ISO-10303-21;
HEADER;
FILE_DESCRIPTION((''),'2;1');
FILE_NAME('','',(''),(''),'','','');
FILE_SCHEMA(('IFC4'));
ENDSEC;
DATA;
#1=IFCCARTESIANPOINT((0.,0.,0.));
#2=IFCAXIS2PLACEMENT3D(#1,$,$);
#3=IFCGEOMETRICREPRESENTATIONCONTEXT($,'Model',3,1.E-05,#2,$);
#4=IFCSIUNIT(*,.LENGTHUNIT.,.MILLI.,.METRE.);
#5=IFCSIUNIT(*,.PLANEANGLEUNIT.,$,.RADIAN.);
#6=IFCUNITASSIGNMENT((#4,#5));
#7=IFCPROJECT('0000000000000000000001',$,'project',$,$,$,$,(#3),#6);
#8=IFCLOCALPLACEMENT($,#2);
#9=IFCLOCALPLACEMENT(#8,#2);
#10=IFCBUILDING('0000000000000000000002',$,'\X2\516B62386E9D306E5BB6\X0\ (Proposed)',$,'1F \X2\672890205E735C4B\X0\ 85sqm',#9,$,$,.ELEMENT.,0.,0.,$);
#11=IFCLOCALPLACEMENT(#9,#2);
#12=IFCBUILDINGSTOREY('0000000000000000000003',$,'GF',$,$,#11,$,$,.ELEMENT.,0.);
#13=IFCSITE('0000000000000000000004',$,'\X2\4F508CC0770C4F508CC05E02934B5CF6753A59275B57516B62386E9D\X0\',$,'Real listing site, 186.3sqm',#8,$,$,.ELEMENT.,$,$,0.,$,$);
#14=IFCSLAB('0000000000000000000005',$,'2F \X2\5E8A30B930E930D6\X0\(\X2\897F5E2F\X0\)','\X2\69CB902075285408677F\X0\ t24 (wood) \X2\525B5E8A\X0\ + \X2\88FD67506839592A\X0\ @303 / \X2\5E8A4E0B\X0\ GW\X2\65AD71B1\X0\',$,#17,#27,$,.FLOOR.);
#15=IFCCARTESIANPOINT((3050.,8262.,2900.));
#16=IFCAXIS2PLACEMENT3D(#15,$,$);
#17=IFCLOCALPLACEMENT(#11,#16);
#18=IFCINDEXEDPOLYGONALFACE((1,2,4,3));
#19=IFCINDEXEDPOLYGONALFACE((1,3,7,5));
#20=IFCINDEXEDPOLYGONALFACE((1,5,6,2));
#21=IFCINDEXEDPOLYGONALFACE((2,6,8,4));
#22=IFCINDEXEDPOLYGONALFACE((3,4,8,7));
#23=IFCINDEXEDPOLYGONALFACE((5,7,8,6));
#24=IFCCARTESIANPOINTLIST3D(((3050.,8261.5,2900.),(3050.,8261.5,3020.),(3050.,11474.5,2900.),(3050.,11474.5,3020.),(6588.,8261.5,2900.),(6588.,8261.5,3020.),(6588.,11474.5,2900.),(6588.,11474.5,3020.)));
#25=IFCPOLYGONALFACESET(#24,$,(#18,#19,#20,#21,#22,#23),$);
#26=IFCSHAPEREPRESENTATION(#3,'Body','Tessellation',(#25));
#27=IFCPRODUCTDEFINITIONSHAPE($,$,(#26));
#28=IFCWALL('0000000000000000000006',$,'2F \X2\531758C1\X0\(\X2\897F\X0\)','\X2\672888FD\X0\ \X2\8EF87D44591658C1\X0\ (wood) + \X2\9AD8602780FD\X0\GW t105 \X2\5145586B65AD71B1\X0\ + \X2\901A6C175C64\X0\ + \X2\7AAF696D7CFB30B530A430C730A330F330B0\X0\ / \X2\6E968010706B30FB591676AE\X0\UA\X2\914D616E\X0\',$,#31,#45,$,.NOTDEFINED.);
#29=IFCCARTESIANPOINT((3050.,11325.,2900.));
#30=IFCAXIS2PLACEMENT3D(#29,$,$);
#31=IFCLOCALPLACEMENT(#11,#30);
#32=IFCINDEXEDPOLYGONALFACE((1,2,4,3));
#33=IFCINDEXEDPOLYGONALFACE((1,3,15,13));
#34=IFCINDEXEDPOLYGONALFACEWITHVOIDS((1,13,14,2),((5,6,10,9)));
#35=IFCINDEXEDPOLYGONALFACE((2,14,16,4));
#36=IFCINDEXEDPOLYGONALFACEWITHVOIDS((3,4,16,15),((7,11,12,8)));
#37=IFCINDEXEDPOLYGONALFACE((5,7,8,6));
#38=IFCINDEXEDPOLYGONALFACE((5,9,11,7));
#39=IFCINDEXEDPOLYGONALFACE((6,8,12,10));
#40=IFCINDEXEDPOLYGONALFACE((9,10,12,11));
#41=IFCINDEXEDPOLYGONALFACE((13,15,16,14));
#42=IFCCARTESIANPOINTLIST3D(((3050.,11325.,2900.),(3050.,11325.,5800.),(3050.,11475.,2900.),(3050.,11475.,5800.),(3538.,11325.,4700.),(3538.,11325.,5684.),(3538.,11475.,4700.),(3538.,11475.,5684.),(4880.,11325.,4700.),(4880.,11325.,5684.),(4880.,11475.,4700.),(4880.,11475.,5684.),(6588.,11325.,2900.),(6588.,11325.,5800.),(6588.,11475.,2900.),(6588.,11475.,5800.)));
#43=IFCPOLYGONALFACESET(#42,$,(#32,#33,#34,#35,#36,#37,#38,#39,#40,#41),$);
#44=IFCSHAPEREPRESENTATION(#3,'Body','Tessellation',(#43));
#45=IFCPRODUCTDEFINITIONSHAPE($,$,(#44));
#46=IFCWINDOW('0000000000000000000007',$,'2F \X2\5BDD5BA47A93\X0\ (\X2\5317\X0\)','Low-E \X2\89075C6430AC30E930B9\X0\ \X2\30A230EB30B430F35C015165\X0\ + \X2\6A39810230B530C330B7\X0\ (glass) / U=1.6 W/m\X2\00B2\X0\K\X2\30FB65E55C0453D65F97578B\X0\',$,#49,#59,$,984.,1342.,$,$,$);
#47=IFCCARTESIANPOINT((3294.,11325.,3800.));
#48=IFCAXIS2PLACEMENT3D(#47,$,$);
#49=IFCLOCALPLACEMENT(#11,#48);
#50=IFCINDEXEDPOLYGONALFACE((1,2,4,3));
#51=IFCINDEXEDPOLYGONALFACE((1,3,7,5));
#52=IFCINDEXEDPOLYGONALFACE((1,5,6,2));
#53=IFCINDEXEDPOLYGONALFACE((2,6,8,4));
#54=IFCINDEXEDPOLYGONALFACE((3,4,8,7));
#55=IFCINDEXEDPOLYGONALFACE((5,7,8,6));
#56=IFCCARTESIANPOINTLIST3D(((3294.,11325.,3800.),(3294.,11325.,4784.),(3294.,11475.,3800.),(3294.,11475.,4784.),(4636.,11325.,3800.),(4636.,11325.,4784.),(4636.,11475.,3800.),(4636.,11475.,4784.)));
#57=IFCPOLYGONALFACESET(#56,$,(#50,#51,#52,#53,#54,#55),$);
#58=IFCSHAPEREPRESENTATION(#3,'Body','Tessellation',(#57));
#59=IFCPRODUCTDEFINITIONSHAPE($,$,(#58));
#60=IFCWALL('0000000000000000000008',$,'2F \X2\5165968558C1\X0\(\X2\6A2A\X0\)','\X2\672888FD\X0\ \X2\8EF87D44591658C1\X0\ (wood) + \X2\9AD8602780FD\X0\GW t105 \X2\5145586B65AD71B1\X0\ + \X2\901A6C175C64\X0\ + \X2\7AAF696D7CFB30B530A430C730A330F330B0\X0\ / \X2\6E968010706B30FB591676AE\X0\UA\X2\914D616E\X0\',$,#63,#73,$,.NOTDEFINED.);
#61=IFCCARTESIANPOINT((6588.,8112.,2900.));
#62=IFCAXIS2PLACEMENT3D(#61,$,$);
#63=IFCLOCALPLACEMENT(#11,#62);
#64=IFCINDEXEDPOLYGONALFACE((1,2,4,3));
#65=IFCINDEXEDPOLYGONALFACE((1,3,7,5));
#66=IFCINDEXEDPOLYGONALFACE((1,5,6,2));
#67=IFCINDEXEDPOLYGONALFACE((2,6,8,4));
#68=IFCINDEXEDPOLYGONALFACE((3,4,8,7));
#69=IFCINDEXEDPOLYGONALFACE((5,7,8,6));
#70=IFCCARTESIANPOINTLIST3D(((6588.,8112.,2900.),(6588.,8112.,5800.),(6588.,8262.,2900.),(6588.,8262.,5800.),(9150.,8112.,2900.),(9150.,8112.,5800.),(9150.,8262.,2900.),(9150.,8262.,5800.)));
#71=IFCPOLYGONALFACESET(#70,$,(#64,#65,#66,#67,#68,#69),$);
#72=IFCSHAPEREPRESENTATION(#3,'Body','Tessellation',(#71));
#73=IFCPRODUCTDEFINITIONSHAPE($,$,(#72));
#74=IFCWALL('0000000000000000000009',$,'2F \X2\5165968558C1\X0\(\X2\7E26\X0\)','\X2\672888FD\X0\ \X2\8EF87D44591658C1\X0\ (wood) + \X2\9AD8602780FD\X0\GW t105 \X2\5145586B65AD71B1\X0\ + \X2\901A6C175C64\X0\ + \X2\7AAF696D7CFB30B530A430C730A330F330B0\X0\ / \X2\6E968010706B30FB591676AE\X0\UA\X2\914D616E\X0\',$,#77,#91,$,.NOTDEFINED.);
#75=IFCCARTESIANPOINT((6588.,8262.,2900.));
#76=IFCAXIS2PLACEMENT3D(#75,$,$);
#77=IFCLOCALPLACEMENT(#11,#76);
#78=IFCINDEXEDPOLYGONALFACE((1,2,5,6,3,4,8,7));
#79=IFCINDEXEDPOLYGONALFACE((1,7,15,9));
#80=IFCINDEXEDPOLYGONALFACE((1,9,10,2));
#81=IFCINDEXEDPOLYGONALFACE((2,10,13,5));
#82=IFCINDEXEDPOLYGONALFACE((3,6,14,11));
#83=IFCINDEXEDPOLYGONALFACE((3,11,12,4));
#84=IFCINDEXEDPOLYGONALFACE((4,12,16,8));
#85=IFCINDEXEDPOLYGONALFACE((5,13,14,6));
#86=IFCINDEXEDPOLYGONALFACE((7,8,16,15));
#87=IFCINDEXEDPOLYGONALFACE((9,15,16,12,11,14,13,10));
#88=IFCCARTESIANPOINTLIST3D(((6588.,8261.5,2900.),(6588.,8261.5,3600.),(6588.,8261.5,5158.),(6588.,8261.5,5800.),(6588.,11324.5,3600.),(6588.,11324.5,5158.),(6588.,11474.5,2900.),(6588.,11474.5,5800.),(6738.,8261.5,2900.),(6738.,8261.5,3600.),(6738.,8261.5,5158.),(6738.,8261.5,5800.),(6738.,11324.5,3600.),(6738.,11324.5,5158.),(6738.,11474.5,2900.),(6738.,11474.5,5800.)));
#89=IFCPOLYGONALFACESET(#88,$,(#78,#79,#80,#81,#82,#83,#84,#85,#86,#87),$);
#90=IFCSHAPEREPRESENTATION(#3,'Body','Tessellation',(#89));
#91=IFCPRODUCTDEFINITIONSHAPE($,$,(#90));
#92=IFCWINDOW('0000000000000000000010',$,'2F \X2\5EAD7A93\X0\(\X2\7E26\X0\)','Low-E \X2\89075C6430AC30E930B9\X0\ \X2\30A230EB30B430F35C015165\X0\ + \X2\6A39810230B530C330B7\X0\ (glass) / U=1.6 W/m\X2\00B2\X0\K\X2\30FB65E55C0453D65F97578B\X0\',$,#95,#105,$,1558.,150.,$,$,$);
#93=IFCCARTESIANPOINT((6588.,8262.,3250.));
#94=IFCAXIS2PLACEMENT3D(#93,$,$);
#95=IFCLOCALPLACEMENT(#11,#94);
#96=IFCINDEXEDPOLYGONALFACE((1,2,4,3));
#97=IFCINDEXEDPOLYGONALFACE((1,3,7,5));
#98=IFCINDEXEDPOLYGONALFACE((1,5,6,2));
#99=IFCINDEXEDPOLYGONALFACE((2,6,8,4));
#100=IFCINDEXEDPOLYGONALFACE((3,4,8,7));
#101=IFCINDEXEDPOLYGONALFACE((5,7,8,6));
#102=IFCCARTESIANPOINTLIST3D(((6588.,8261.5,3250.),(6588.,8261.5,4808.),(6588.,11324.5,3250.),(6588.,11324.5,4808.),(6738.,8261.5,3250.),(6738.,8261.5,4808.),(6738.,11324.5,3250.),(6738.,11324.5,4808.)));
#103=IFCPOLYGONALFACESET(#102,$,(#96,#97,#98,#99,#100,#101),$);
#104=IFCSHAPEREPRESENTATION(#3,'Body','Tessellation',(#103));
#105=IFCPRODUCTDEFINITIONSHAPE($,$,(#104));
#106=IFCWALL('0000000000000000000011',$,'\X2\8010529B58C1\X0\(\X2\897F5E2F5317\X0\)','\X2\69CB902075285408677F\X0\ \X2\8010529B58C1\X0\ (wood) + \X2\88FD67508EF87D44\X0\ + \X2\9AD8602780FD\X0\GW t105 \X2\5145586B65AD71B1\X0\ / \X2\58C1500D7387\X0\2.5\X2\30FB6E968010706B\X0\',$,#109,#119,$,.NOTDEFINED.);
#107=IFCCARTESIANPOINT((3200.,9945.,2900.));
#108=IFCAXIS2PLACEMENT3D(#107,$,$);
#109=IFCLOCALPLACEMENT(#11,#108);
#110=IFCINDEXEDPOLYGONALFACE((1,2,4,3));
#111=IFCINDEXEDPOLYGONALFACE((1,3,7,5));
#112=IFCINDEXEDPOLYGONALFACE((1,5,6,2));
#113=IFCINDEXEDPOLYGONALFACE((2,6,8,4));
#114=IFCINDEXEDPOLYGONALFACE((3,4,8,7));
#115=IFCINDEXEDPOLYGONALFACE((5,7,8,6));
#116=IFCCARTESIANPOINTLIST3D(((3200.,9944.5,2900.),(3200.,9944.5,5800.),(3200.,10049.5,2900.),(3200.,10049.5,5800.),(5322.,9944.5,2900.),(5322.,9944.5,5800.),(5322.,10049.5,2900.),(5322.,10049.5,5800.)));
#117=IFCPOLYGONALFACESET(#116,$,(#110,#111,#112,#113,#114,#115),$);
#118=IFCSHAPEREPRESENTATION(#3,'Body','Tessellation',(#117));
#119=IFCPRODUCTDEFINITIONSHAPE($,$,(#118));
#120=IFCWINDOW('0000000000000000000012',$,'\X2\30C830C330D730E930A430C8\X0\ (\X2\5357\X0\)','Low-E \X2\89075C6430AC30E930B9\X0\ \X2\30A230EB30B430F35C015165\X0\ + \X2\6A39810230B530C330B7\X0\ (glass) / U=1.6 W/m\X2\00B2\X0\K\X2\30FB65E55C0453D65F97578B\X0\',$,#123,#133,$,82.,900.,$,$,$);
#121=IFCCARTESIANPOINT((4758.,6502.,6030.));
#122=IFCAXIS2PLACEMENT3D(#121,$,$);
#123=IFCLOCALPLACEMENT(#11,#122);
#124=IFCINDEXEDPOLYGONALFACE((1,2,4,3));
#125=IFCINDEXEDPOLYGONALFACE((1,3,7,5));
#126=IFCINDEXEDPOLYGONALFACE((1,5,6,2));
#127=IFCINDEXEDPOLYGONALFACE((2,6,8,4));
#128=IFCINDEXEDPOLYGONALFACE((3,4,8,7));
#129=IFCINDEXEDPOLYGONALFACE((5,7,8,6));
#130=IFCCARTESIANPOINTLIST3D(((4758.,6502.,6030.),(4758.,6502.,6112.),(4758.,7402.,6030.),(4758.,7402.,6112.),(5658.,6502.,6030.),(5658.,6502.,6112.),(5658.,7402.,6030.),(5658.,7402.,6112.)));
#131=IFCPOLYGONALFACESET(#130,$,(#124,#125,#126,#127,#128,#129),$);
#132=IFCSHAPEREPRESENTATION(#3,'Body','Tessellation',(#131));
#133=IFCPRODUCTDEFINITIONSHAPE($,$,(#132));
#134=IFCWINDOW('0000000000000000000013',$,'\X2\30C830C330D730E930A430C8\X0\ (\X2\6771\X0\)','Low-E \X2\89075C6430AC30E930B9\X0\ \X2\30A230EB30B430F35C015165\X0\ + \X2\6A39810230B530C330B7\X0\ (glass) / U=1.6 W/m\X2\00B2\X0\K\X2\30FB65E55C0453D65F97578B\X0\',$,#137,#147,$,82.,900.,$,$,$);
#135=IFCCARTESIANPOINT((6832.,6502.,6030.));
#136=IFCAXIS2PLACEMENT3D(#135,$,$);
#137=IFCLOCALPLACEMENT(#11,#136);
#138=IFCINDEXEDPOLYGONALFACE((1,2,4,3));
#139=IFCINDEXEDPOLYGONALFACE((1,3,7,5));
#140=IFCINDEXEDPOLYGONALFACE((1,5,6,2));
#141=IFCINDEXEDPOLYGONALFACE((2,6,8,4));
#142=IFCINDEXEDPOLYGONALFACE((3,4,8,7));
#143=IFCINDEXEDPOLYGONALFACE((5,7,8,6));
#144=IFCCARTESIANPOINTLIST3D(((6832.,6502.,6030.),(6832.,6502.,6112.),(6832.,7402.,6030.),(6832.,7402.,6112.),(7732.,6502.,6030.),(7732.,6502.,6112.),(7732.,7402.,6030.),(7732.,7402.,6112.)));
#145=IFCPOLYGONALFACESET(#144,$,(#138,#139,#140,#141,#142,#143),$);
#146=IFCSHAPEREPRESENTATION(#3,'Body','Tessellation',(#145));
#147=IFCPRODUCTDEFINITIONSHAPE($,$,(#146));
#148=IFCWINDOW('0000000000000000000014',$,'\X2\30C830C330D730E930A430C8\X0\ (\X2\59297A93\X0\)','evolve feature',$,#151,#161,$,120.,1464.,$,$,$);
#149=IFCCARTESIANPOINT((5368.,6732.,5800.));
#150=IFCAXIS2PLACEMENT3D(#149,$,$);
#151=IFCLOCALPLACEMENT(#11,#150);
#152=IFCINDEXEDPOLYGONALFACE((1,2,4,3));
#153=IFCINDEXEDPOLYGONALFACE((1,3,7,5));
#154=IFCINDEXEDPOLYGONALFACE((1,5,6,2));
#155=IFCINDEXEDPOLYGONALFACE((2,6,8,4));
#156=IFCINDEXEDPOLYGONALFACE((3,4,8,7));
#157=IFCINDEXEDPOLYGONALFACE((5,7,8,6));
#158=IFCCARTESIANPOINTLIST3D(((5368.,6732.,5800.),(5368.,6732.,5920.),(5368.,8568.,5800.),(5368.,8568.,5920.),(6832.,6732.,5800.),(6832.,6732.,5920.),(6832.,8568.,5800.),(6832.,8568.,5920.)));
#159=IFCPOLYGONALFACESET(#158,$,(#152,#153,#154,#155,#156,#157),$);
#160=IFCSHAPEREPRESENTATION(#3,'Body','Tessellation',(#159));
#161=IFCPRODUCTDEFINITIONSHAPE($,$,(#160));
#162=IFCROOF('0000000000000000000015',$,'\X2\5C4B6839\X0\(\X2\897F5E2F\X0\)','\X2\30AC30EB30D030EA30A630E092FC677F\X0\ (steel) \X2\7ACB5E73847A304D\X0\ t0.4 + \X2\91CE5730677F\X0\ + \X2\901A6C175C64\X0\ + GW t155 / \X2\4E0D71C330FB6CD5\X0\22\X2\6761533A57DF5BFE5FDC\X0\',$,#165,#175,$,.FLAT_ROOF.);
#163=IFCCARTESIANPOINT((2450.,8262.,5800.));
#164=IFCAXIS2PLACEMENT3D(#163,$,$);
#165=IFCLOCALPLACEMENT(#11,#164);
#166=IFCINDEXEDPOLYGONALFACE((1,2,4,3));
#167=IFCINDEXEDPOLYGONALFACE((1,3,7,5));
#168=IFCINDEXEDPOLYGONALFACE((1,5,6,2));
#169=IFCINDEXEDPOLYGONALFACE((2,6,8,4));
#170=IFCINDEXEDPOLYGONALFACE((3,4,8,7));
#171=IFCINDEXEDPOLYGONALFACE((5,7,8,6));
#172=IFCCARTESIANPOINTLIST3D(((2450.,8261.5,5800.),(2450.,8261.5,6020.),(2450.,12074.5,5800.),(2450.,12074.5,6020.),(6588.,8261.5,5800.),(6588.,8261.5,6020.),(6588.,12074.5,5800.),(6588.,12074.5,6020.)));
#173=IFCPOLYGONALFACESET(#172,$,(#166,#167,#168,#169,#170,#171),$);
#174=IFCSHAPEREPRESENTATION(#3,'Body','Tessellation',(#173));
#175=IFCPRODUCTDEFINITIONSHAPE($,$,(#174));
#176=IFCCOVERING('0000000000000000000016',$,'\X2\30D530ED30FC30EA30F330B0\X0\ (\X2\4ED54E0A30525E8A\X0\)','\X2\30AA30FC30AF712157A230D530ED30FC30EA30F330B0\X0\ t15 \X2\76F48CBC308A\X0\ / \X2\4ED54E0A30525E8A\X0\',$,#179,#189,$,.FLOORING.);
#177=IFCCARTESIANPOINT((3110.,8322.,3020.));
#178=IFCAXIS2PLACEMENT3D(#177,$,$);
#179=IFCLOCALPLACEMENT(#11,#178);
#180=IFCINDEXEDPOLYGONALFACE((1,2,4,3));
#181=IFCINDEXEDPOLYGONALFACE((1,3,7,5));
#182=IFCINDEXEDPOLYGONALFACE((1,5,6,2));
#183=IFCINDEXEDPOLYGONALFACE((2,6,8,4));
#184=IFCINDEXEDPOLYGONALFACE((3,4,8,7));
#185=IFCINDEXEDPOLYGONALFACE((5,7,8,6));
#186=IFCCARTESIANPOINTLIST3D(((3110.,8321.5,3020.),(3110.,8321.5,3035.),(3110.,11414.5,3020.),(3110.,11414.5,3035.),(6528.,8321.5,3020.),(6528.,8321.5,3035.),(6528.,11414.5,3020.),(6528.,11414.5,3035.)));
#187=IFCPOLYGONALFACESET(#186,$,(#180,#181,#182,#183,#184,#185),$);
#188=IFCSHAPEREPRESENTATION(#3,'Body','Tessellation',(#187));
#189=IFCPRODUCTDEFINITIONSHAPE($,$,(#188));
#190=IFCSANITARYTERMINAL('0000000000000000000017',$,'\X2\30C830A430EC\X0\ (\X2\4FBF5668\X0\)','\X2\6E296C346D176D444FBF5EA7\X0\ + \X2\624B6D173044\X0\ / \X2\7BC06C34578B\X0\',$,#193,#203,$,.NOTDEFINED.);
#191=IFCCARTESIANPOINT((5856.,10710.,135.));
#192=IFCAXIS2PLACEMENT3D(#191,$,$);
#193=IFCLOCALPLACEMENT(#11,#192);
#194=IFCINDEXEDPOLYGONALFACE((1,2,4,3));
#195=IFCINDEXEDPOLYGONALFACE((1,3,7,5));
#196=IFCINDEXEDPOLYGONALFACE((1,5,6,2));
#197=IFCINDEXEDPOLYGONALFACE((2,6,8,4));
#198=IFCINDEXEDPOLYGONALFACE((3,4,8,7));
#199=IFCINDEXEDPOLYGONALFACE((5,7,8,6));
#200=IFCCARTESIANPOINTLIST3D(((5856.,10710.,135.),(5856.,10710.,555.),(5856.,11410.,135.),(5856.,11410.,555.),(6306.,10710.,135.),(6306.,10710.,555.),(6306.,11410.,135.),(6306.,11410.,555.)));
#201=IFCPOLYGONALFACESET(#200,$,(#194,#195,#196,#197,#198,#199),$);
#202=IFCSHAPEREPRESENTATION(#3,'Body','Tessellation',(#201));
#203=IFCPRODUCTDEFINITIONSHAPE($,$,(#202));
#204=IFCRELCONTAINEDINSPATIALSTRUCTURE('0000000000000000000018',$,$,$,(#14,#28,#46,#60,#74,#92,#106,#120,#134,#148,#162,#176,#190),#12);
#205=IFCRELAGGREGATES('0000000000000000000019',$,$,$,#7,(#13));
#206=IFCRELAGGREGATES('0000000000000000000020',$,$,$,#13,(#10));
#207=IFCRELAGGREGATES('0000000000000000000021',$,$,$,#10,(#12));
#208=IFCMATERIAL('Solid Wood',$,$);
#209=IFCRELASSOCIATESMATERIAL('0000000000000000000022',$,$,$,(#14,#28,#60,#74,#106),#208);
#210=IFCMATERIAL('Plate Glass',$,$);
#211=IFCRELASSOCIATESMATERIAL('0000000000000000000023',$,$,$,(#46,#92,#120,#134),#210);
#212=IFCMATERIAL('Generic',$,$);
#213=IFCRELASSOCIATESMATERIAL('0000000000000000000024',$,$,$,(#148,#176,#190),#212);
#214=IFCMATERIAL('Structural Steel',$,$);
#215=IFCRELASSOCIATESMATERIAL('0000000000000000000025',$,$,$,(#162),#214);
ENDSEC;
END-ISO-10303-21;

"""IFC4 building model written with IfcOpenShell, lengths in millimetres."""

from ifc_helpers import new_model, si_unit, frame, frame_2d, origin, place, context, project, spatial, rectangle, extrude, material, element, fill, save


model = new_model("IFC4")

# Units and contexts
model_context = context("Model", 3, precision=1e-05, world=origin())
ifc_project = project(units=[si_unit("LENGTHUNIT", "METRE", prefix="MILLI"), si_unit("PLANEANGLEUNIT", "RADIAN")], contexts=[model_context])

# Site, building, storey
site_placement = place(None, origin())
site = spatial("IfcSite", under=ifc_project, at=site_placement, Name="佐賀県佐賀市鍋島町大字八戸溝", ObjectType="Real listing site, 186.3sqm", CompositionType="ELEMENT", RefElevation=0.0)
building_placement = place(site_placement, origin())
building = spatial("IfcBuilding", under=site, at=building_placement, Name="八戸溝の家 (Proposed)", ObjectType="1F 木造平屋 85sqm", CompositionType="ELEMENT", ElevationOfRefHeight=0.0, ElevationOfTerrain=0.0)
storey_placement = place(building_placement, origin())
storey = spatial("IfcBuildingStorey", under=building, at=storey_placement, Name="GF", CompositionType="ELEMENT", Elevation=0.0)

# Slab
ifc_material_1 = material(Name="Solid Wood")
slab_placement = place(storey_placement, frame((3050.0, 8262.0, 2900.0)))
element("IfcSlab", 1, at=slab_placement, inside=storey, material=ifc_material_1, Name="2F 床スラブ(西帯)", Description="構造用合板 t24 (wood) 剛床 + 製材根太 @303 / 床下 GW断熱", PredefinedType="FLOOR", context=model_context, shape_type="SweptSolid", body=[
    extrude(rectangle(XDim=3538.0, YDim=3213.0, at=frame_2d((1769.0, 1606.0))), frame((3050.0, 8262.0, 2900.0)), (0.0, 0.0, 1.0), 120.0),
])

# Wall, opening, window
wall_1_placement = place(storey_placement, frame((3050.0, 11325.0, 2900.0)))
wall_1 = element("IfcWall", 2, at=wall_1_placement, inside=storey, material=ifc_material_1, Name="2F 北壁(西)", Description="木製 軸組外壁 (wood) + 高性能GW t105 充填断熱 + 通気層 + 窯業系サイディング / 準耐火・外皮UA配慮", PredefinedType="NOTDEFINED", context=model_context, shape_type="SweptSolid", body=[
    extrude(rectangle(XDim=3538.0, YDim=150.0, at=frame_2d((1769.0, 75.0))), frame((3050.0, 11325.0, 2900.0)), (0.0, 0.0, 1.0), 2900.0),
])
opening_1_placement = place(storey_placement, frame((3294.0, 11325.0, 3800.0)))
opening_1 = element("IfcOpeningElement", 3, at=opening_1_placement, cuts=wall_1, PredefinedType="NOTDEFINED", context=model_context, shape_type="SweptSolid", body=[
    extrude(rectangle(XDim=1342.0, YDim=150.0, at=frame_2d((671.0, 75.0))), frame((3294.0, 11325.0, 3800.0)), (0.0, 0.0, 1.0), 984.0),
])
ifc_material_2 = material(Name="Plate Glass")
window_1_placement = place(storey_placement, frame((3294.0, 11325.0, 3800.0)))
window_1 = element("IfcWindow", 4, at=window_1_placement, inside=storey, material=ifc_material_2, Name="2F 寝室窓 (北)", Description="Low-E 複層ガラス アルゴン封入 + 樹脂サッシ (glass) / U=1.6 W/m²K・日射取得型", OverallHeight=984.0, OverallWidth=1342.0, context=model_context, shape_type="SweptSolid", body=[
    extrude(rectangle(XDim=1342.0, YDim=150.0, at=frame_2d((671.0, 75.0))), frame((3294.0, 11325.0, 3800.0)), (0.0, 0.0, 1.0), 984.0),
])
fill(opening_1, window_1)

# Wall
wall_2_placement = place(storey_placement, frame((6588.0, 8112.0, 2900.0)))
element("IfcWall", 5, at=wall_2_placement, inside=storey, material=ifc_material_1, Name="2F 入隅壁(横)", Description="木製 軸組外壁 (wood) + 高性能GW t105 充填断熱 + 通気層 + 窯業系サイディング / 準耐火・外皮UA配慮", PredefinedType="NOTDEFINED", context=model_context, shape_type="SweptSolid", body=[
    extrude(rectangle(XDim=2562.0, YDim=150.0, at=frame_2d((1281.0, 75.0))), frame((6588.0, 8112.0, 2900.0)), (0.0, 0.0, 1.0), 2900.0),
])

# Wall, opening, window
wall_3_placement = place(storey_placement, frame((6588.0, 8262.0, 2900.0)))
wall_3 = element("IfcWall", 6, at=wall_3_placement, inside=storey, material=ifc_material_1, Name="2F 入隅壁(縦)", Description="木製 軸組外壁 (wood) + 高性能GW t105 充填断熱 + 通気層 + 窯業系サイディング / 準耐火・外皮UA配慮", PredefinedType="NOTDEFINED", context=model_context, shape_type="SweptSolid", body=[
    extrude(rectangle(XDim=150.0, YDim=3213.0, at=frame_2d((75.0, 1606.0))), frame((6588.0, 8262.0, 2900.0)), (0.0, 0.0, 1.0), 2900.0),
])
opening_2_placement = place(storey_placement, frame((6588.0, 8262.0, 3250.0)))
opening_2 = element("IfcOpeningElement", 7, at=opening_2_placement, cuts=wall_3, PredefinedType="NOTDEFINED", context=model_context, shape_type="SweptSolid", body=[
    extrude(rectangle(XDim=150.0, YDim=3063.0, at=frame_2d((75.0, 1531.0))), frame((6588.0, 8262.0, 3250.0)), (0.0, 0.0, 1.0), 1558.0),
])
window_2_placement = place(storey_placement, frame((6588.0, 8262.0, 3250.0)))
window_2 = element("IfcWindow", 8, at=window_2_placement, inside=storey, material=ifc_material_2, Name="2F 庭窓(縦)", Description="Low-E 複層ガラス アルゴン封入 + 樹脂サッシ (glass) / U=1.6 W/m²K・日射取得型", OverallHeight=1558.0, OverallWidth=150.0, context=model_context, shape_type="SweptSolid", body=[
    extrude(rectangle(XDim=150.0, YDim=3063.0, at=frame_2d((75.0, 1531.0))), frame((6588.0, 8262.0, 3250.0)), (0.0, 0.0, 1.0), 1558.0),
])
fill(opening_2, window_2)

# Wall
wall_4_placement = place(storey_placement, frame((3200.0, 9945.0, 2900.0)))
element("IfcWall", 9, at=wall_4_placement, inside=storey, material=ifc_material_1, Name="耐力壁(西帯北)", Description="構造用合板 耐力壁 (wood) + 製材軸組 + 高性能GW t105 充填断熱 / 壁倍率2.5・準耐火", PredefinedType="NOTDEFINED", context=model_context, shape_type="SweptSolid", body=[
    extrude(rectangle(XDim=2122.0, YDim=105.0, at=frame_2d((1061.0, 52.0))), frame((3200.0, 9945.0, 2900.0)), (0.0, 0.0, 1.0), 2900.0),
])

# Windows
window_3_placement = place(storey_placement, frame((4758.0, 6502.0, 6030.0)))
element("IfcWindow", 10, at=window_3_placement, inside=storey, material=ifc_material_2, Name="トップライト (南)", Description="Low-E 複層ガラス アルゴン封入 + 樹脂サッシ (glass) / U=1.6 W/m²K・日射取得型", OverallHeight=82.0, OverallWidth=900.0, context=model_context, shape_type="SweptSolid", body=[
    extrude(rectangle(XDim=900.0, YDim=900.0, at=frame_2d((450.0, 450.0))), frame((4758.0, 6502.0, 6030.0)), (0.0, 0.0, 1.0), 82.0),
])
window_4_placement = place(storey_placement, frame((6832.0, 6502.0, 6030.0)))
element("IfcWindow", 11, at=window_4_placement, inside=storey, material=ifc_material_2, Name="トップライト (東)", Description="Low-E 複層ガラス アルゴン封入 + 樹脂サッシ (glass) / U=1.6 W/m²K・日射取得型", OverallHeight=82.0, OverallWidth=900.0, context=model_context, shape_type="SweptSolid", body=[
    extrude(rectangle(XDim=900.0, YDim=900.0, at=frame_2d((450.0, 450.0))), frame((6832.0, 6502.0, 6030.0)), (0.0, 0.0, 1.0), 82.0),
])
ifc_material_3 = material(Name="Generic")
window_5_placement = place(storey_placement, frame((5368.0, 6732.0, 5800.0)))
element("IfcWindow", 12, at=window_5_placement, inside=storey, material=ifc_material_3, Name="トップライト (天窓)", Description="evolve feature", OverallHeight=120.0, OverallWidth=1464.0, context=model_context, shape_type="SweptSolid", body=[
    extrude(rectangle(XDim=1464.0, YDim=1836.0, at=frame_2d((732.0, 918.0))), frame((5368.0, 6732.0, 5800.0)), (0.0, 0.0, 1.0), 120.0),
])

# Roof
ifc_material_4 = material(Name="Structural Steel")
for number, where, name in (
    (13, (2450.0, 8262.0, 5800.0), "屋根(西帯)"),
):
    element("IfcRoof", number, at=place(storey_placement, frame(where)), inside=storey, material=ifc_material_4, Name=name, Description="ガルバリウム鋼板 (steel) 立平葺き t0.4 + 野地板 + 通気層 + GW t155 / 不燃・法22条区域対応", PredefinedType="FLAT_ROOF", context=model_context, shape_type="SweptSolid", body=[
        extrude(rectangle(XDim=4138.0, YDim=3813.0, at=frame_2d((2069.0, 1906.0))), frame((2450.0, 8262.0, 5800.0)), (0.0, 0.0, 1.0), 220.0),
    ])

# Covering
covering_placement = place(storey_placement, frame((3110.0, 8322.0, 3020.0)))
element("IfcCovering", 14, at=covering_placement, inside=storey, material=ifc_material_3, Name="フローリング (仕上げ床)", Description="オーク無垢フローリング t15 直貼り / 仕上げ床", PredefinedType="FLOORING", context=model_context, shape_type="SweptSolid", body=[
    extrude(rectangle(XDim=3418.0, YDim=3093.0, at=frame_2d((1709.0, 1546.0))), frame((3110.0, 8322.0, 3020.0)), (0.0, 0.0, 1.0), 15.0),
])

# Sanitary terminal
sanitary_terminal_placement = place(storey_placement, frame((5856.0, 10710.0, 135.0)))
element("IfcSanitaryTerminal", 15, at=sanitary_terminal_placement, inside=storey, material=ifc_material_3, Name="トイレ (便器)", Description="温水洗浄便座 + 手洗い / 節水型", PredefinedType="NOTDEFINED", context=model_context, shape_type="SweptSolid", body=[
    extrude(rectangle(XDim=450.0, YDim=700.0, at=frame_2d((225.0, 350.0))), frame((5856.0, 10710.0, 135.0)), (0.0, 0.0, 1.0), 420.0),
])

save(model, "model.ifc")
